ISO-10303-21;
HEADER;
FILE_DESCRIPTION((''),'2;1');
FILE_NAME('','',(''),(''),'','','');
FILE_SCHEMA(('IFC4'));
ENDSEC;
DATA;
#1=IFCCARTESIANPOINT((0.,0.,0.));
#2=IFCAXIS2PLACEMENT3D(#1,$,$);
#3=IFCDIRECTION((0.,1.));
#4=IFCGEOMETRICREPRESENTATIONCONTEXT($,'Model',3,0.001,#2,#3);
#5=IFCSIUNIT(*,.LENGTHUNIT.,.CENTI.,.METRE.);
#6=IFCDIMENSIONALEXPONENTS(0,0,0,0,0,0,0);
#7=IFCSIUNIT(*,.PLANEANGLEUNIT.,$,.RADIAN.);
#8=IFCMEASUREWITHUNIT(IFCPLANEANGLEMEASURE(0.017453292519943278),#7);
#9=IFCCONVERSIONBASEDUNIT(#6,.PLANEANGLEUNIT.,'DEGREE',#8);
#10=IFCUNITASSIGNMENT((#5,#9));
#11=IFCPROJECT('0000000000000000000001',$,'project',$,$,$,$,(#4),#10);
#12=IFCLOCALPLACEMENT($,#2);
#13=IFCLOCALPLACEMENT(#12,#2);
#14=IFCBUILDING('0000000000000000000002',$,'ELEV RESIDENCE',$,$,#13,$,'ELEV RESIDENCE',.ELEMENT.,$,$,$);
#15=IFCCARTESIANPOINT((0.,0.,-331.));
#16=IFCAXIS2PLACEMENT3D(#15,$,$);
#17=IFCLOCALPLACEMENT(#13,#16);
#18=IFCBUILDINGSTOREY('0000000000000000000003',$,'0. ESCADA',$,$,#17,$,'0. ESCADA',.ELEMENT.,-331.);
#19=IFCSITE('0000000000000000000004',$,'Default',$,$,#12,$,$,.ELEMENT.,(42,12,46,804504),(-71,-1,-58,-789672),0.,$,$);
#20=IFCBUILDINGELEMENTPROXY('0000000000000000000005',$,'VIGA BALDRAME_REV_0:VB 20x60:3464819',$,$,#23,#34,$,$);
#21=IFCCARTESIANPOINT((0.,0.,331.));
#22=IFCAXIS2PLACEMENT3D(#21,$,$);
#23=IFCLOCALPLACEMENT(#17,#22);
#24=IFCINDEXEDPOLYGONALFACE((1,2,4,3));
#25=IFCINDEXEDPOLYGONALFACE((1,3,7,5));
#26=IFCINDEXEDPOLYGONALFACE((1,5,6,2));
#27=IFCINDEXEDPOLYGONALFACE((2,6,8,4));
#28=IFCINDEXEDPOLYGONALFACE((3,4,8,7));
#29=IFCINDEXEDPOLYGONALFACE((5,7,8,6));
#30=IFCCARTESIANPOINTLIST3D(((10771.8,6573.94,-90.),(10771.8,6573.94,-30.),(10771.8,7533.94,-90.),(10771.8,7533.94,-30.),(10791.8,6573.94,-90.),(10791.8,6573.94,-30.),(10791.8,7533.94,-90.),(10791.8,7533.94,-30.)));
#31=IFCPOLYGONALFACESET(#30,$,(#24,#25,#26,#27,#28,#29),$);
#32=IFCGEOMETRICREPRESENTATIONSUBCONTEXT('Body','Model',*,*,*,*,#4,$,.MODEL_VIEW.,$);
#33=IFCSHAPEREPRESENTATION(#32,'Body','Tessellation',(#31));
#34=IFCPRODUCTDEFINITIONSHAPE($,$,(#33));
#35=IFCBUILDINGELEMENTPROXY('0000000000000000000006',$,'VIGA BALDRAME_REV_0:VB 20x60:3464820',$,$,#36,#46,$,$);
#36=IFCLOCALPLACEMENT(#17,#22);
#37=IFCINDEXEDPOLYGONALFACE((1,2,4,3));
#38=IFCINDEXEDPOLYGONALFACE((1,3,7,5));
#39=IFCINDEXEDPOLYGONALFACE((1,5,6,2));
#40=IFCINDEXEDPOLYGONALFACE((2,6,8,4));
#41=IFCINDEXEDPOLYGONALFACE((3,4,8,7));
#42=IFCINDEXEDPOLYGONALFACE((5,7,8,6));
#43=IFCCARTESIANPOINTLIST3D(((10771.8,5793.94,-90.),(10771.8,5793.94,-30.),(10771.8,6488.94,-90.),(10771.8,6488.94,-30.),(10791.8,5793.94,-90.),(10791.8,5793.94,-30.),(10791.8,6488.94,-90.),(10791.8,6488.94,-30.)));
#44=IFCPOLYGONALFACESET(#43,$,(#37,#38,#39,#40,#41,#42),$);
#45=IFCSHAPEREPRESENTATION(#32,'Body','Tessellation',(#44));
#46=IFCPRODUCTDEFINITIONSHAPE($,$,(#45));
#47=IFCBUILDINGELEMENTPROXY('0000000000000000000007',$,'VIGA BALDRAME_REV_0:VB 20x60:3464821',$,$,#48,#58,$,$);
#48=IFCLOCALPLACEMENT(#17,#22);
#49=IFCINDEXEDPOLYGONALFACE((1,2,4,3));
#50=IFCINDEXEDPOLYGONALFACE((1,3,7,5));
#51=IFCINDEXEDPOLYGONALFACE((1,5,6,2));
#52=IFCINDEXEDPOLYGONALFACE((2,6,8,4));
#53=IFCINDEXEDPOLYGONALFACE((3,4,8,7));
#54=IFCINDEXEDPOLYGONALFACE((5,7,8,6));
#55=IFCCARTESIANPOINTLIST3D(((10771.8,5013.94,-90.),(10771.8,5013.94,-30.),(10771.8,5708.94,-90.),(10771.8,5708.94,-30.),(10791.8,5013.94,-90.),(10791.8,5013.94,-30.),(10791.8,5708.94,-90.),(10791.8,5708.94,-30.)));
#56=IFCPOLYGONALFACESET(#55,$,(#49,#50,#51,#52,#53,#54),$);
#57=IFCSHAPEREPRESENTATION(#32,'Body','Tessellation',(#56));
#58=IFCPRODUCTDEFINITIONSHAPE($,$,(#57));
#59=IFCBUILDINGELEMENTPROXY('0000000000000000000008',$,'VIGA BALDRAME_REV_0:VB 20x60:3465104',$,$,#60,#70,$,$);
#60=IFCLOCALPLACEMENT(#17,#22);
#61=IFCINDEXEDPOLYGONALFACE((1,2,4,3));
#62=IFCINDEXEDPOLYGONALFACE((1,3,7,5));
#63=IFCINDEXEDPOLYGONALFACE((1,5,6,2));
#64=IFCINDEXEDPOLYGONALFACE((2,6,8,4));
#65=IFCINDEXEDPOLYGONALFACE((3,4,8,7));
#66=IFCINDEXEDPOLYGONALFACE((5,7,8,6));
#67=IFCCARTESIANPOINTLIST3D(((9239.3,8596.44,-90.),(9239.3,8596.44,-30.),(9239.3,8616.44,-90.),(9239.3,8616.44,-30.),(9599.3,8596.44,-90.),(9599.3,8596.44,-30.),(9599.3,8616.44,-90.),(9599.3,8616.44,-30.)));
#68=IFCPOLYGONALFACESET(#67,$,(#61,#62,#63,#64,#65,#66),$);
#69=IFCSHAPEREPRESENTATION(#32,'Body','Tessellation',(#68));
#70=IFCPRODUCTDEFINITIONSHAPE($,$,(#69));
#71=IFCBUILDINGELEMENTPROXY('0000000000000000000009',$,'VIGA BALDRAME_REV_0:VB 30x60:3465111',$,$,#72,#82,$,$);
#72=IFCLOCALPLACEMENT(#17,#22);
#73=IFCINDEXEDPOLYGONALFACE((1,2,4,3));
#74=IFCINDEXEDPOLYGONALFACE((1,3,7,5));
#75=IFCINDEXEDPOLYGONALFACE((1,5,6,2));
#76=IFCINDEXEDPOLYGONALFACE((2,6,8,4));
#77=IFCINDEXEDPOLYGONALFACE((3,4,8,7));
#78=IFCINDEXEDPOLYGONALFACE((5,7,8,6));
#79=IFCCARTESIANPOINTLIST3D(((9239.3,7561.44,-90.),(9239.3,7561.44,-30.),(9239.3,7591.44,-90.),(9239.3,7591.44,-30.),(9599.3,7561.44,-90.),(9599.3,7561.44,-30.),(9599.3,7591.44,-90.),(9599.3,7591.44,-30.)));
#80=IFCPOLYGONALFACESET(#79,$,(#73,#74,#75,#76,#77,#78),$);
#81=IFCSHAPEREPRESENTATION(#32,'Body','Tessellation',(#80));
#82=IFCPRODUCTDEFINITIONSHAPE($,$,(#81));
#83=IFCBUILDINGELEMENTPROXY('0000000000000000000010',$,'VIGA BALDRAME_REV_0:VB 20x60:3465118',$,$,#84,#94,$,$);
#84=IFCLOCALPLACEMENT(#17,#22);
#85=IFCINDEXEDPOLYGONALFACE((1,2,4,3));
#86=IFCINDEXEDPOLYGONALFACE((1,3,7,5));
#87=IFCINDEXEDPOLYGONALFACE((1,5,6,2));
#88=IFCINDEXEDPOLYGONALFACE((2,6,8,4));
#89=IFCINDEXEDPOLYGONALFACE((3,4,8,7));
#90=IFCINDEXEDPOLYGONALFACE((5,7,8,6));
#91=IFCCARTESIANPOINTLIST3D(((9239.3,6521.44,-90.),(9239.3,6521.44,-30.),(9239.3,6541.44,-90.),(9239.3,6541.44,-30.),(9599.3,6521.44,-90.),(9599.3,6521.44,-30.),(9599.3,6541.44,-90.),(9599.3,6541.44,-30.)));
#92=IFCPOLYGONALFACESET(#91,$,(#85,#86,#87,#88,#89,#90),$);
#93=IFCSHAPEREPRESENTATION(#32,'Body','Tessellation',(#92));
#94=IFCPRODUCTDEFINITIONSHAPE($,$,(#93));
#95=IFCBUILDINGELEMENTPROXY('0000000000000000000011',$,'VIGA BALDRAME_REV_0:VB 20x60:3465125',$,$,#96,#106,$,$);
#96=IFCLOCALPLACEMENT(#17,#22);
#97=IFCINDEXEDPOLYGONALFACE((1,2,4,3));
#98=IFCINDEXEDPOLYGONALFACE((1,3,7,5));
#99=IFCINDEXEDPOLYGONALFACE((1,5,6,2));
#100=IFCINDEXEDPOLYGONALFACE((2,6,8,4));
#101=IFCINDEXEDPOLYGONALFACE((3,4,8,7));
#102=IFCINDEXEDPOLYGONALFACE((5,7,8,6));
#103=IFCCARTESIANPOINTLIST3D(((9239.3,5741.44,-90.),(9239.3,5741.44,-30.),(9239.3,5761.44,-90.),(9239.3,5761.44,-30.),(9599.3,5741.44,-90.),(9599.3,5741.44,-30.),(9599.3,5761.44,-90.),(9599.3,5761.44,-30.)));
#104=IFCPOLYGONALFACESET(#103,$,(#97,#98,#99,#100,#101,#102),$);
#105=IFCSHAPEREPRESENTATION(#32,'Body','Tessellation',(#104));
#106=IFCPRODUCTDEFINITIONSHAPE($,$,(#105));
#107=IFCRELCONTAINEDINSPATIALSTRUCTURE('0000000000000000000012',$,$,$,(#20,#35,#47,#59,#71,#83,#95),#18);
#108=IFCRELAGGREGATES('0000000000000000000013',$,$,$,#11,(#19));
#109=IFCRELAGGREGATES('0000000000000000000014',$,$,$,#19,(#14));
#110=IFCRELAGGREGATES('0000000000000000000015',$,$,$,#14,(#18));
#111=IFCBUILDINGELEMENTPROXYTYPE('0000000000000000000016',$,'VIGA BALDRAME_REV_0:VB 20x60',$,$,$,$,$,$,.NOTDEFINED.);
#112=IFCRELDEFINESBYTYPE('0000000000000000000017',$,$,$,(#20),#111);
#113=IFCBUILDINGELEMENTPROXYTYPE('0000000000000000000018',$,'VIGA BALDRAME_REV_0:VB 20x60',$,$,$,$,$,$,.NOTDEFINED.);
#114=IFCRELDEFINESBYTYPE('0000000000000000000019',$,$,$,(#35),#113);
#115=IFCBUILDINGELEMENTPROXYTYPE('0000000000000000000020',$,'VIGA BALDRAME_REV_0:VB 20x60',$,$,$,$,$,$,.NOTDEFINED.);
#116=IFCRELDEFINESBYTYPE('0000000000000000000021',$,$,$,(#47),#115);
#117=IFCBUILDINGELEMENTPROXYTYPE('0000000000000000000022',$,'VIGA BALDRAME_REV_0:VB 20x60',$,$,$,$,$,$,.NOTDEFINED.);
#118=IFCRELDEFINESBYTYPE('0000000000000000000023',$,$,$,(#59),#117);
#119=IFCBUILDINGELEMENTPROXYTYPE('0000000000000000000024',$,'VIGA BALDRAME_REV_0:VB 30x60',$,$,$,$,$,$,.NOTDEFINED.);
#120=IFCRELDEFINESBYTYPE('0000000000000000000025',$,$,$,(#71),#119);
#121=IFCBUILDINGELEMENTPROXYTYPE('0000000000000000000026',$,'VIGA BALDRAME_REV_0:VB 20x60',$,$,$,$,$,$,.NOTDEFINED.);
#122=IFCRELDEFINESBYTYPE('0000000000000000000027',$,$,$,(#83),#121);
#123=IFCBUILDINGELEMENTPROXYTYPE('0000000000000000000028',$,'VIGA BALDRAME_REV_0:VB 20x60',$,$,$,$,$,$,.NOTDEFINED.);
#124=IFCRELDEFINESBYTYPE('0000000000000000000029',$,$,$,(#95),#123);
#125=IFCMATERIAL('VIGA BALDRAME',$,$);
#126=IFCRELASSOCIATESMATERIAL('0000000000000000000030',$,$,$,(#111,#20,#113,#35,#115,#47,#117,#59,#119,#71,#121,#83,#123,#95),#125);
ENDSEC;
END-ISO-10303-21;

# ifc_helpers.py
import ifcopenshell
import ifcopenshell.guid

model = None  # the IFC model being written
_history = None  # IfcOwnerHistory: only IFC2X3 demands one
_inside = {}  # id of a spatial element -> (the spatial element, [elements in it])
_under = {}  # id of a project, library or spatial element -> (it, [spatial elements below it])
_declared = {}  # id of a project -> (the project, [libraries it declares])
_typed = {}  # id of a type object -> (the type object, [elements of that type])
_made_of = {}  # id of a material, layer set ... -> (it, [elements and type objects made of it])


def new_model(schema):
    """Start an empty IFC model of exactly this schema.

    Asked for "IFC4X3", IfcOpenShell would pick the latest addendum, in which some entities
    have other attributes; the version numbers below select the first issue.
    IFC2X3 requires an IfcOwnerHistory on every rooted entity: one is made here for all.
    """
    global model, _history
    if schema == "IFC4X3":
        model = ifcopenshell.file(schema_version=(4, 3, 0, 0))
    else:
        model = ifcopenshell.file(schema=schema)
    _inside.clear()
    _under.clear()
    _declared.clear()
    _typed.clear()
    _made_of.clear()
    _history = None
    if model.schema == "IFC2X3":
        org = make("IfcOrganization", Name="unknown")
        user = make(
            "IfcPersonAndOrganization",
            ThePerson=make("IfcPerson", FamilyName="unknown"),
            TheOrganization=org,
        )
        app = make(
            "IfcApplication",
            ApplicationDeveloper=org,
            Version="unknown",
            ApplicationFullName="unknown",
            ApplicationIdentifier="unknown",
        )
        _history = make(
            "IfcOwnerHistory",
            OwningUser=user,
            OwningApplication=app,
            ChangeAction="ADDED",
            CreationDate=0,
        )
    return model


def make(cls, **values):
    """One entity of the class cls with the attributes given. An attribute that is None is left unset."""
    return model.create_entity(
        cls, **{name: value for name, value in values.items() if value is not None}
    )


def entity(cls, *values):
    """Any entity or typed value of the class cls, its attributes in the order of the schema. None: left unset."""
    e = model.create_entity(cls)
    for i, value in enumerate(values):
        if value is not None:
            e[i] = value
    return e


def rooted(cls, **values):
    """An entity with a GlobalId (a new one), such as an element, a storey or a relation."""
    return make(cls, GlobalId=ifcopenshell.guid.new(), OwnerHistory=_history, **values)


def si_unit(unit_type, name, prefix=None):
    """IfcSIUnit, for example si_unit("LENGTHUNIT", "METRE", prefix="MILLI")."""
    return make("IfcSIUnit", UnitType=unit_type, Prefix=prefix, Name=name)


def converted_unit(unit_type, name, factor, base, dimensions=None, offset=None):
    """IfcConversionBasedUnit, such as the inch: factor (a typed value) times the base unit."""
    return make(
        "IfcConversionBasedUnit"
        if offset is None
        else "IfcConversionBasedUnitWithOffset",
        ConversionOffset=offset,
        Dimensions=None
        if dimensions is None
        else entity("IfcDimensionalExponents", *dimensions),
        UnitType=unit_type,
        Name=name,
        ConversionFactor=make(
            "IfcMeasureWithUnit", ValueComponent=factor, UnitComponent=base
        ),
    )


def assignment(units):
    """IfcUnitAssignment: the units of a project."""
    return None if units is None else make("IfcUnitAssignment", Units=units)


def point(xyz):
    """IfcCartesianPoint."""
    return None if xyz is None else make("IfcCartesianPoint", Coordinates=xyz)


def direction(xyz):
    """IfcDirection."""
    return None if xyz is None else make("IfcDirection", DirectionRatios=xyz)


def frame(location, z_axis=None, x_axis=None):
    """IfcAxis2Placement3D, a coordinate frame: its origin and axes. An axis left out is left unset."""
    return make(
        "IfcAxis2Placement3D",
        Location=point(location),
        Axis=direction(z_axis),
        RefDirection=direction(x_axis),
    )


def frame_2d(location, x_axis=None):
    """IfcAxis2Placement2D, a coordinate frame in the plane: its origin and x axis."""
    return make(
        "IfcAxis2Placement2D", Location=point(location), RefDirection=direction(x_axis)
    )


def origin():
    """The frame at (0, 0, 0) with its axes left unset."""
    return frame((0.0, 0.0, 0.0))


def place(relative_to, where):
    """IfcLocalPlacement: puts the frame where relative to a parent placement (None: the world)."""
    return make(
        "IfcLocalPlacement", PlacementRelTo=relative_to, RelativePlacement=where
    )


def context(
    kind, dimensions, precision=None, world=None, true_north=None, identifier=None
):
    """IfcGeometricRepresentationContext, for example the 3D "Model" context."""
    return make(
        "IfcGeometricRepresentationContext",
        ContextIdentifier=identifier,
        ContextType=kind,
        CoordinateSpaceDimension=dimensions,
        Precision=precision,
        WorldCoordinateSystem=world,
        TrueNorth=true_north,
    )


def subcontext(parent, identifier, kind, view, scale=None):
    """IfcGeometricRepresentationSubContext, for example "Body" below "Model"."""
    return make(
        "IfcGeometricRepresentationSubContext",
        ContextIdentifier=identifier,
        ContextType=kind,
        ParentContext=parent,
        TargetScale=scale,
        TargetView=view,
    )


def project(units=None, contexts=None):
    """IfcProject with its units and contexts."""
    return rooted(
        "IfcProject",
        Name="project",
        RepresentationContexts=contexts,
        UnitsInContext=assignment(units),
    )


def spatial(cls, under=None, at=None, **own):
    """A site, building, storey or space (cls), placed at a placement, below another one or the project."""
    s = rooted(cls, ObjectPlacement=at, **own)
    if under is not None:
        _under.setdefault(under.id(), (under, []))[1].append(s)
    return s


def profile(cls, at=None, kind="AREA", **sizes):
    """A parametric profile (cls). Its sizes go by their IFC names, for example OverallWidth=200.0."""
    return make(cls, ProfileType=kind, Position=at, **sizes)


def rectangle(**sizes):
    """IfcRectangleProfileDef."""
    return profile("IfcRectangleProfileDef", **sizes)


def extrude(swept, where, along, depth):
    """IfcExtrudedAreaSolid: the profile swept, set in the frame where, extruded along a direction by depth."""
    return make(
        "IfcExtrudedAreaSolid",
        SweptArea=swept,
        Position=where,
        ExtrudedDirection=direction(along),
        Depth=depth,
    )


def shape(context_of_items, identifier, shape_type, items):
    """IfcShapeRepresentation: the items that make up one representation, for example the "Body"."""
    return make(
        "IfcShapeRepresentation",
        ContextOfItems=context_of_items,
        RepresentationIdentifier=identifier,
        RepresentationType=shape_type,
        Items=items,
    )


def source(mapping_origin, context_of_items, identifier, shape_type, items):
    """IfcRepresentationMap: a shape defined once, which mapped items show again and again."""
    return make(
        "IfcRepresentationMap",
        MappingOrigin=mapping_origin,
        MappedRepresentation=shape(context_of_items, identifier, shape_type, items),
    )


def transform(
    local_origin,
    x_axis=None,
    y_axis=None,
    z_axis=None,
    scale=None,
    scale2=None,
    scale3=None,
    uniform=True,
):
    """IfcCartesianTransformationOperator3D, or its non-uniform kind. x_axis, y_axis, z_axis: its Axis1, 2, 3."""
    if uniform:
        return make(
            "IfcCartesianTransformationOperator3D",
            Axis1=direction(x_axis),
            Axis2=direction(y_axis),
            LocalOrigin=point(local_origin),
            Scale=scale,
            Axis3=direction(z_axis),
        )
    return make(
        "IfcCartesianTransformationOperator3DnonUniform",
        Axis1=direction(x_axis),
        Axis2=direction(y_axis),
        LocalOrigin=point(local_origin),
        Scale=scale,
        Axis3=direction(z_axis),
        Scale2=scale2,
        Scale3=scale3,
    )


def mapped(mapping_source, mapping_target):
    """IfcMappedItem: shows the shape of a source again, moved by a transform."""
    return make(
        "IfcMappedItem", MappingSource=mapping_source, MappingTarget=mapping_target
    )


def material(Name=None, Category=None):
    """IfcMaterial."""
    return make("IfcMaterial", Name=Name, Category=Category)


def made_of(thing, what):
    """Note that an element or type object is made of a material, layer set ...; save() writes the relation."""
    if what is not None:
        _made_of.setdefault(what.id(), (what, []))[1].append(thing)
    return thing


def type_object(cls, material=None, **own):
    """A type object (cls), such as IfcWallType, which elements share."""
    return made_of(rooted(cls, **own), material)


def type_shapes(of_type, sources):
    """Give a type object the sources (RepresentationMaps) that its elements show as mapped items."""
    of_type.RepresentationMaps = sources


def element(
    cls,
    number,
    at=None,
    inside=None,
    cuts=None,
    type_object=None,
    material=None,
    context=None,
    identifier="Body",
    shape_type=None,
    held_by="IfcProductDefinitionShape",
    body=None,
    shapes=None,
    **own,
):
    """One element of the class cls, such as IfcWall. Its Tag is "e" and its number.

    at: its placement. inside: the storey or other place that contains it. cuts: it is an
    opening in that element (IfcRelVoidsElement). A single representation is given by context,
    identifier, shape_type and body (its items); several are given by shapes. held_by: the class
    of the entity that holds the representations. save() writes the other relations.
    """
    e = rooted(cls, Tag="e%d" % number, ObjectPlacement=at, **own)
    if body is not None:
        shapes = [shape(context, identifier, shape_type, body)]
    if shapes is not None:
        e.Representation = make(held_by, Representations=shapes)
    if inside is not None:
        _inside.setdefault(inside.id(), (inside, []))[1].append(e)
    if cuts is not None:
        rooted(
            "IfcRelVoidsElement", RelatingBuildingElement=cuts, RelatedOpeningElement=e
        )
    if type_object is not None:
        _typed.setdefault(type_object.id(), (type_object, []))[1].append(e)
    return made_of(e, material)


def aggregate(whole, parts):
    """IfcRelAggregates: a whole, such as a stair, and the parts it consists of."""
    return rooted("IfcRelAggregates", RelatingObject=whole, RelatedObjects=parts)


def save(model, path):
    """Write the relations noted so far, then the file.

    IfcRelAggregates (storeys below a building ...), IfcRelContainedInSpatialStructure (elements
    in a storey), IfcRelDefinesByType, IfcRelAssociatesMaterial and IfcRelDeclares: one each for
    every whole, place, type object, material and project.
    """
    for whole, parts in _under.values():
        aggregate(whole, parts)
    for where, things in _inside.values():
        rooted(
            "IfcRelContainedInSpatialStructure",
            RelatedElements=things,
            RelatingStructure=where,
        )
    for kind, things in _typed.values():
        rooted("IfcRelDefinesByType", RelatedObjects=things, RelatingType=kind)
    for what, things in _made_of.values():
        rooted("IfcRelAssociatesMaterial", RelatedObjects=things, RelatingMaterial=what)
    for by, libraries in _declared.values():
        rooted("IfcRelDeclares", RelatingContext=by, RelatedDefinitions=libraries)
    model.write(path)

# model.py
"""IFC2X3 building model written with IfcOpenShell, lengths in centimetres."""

from ifc_helpers import new_model, entity, si_unit, converted_unit, direction, frame, frame_2d, origin, place, context, subcontext, project, spatial, rectangle, extrude, source, transform, mapped, material, type_object, type_shapes, element, save


model = new_model("IFC2X3")

# Units and contexts
model_context = context("Model", 3, precision=0.001, world=origin(), true_north=direction((0.0, 1.0)))
body_context = subcontext(model_context, "Body", "Model", "MODEL_VIEW")
ifc_project = project(units=[si_unit("LENGTHUNIT", "METRE", prefix="CENTI"), converted_unit("PLANEANGLEUNIT", "DEGREE", entity("IfcPlaneAngleMeasure", 0.017453292519943278), si_unit("PLANEANGLEUNIT", "RADIAN"), dimensions=[0, 0, 0, 0, 0, 0, 0])], contexts=[model_context])

# Site, building, storey
site_placement = place(None, origin())
site = spatial("IfcSite", under=ifc_project, at=site_placement, Name="Default", CompositionType="ELEMENT", RefLatitude=(42, 12, 46, 804504), RefLongitude=(-71, -1, -58, -789672), RefElevation=0.0)
building_placement = place(site_placement, origin())
building = spatial("IfcBuilding", under=site, at=building_placement, Name="ELEV RESIDENCE", LongName="ELEV RESIDENCE", CompositionType="ELEMENT")
storey_placement = place(building_placement, frame((0.0, 0.0, -331.0)))
storey = spatial("IfcBuildingStorey", under=building, at=storey_placement, Name="0. ESCADA", LongName="0. ESCADA", CompositionType="ELEMENT", Elevation=-331.0)

# Building element proxies
ifc_material = material(Name="VIGA BALDRAME")
building_element_proxy_type_1 = type_object("IfcBuildingElementProxyType", Name="VIGA BALDRAME_REV_0:VB 20x60", PredefinedType="NOTDEFINED", material=ifc_material)
shared_shape_1 = source(origin(), body_context, "Body", "SweptSolid", [
    extrude(rectangle(XDim=20.0, YDim=960.0, at=frame_2d((0.0, 0.0), x_axis=(1.0, 0.0))), frame((10781.8, 7053.94, -90.0), z_axis=(0.0, 0.0, 1.0), x_axis=(-1.0, 0.0, 0.0)), (0.0, 0.0, 1.0), 60.0),
])
type_shapes(building_element_proxy_type_1, [shared_shape_1])
proxy_1_placement = place(storey_placement, frame((0.0, 0.0, 331.0)))
element("IfcBuildingElementProxy", 1, at=proxy_1_placement, inside=storey, type_object=building_element_proxy_type_1, material=ifc_material, Name="VIGA BALDRAME_REV_0:VB 20x60:3464819", context=body_context, shape_type="MappedRepresentation", body=[
    mapped(shared_shape_1, transform((0.0, 0.0, 0.0), scale=1.0)),
])
building_element_proxy_type_2 = type_object("IfcBuildingElementProxyType", Name="VIGA BALDRAME_REV_0:VB 20x60", PredefinedType="NOTDEFINED", material=ifc_material)
shared_shape_2 = source(origin(), body_context, "Body", "SweptSolid", [
    extrude(rectangle(XDim=695.0, YDim=20.0, at=frame_2d((0.0, 0.0), x_axis=(1.0, 0.0))), frame((10781.8, 6141.44, -90.0), z_axis=(0.0, 0.0, 1.0), x_axis=(0.0, 1.0, 0.0)), (0.0, 0.0, 1.0), 60.0),
])
type_shapes(building_element_proxy_type_2, [shared_shape_2])
proxy_2_placement = place(storey_placement, frame((0.0, 0.0, 331.0)))
element("IfcBuildingElementProxy", 2, at=proxy_2_placement, inside=storey, type_object=building_element_proxy_type_2, material=ifc_material, Name="VIGA BALDRAME_REV_0:VB 20x60:3464820", context=body_context, shape_type="MappedRepresentation", body=[
    mapped(shared_shape_2, transform((0.0, 0.0, 0.0), scale=1.0)),
])
building_element_proxy_type_3 = type_object("IfcBuildingElementProxyType", Name="VIGA BALDRAME_REV_0:VB 20x60", PredefinedType="NOTDEFINED", material=ifc_material)
shared_shape_3 = source(origin(), body_context, "Body", "SweptSolid", [
    extrude(rectangle(XDim=20.0, YDim=695.0, at=frame_2d((0.0, 0.0), x_axis=(1.0, 0.0))), frame((10781.8, 5361.44, -90.0), z_axis=(0.0, 0.0, 1.0), x_axis=(-1.0, 0.0, 0.0)), (0.0, 0.0, 1.0), 60.0),
])
type_shapes(building_element_proxy_type_3, [shared_shape_3])
proxy_3_placement = place(storey_placement, frame((0.0, 0.0, 331.0)))
element("IfcBuildingElementProxy", 3, at=proxy_3_placement, inside=storey, type_object=building_element_proxy_type_3, material=ifc_material, Name="VIGA BALDRAME_REV_0:VB 20x60:3464821", context=body_context, shape_type="MappedRepresentation", body=[
    mapped(shared_shape_3, transform((0.0, 0.0, 0.0), scale=1.0)),
])
building_element_proxy_type_4 = type_object("IfcBuildingElementProxyType", Name="VIGA BALDRAME_REV_0:VB 20x60", PredefinedType="NOTDEFINED", material=ifc_material)
shared_shape_4 = source(origin(), body_context, "Body", "SweptSolid", [
    extrude(rectangle(XDim=20.0, YDim=360.0, at=frame_2d((0.0, 0.0), x_axis=(1.0, 0.0))), frame((9419.3, 8606.44, -90.0), z_axis=(0.0, 0.0, 1.0), x_axis=(0.0, -1.0, 0.0)), (0.0, 0.0, 1.0), 60.0),
])
type_shapes(building_element_proxy_type_4, [shared_shape_4])
proxy_4_placement = place(storey_placement, frame((0.0, 0.0, 331.0)))
element("IfcBuildingElementProxy", 4, at=proxy_4_placement, inside=storey, type_object=building_element_proxy_type_4, material=ifc_material, Name="VIGA BALDRAME_REV_0:VB 20x60:3465104", context=body_context, shape_type="MappedRepresentation", body=[
    mapped(shared_shape_4, transform((0.0, 0.0, 0.0), scale=1.0)),
])
building_element_proxy_type_5 = type_object("IfcBuildingElementProxyType", Name="VIGA BALDRAME_REV_0:VB 30x60", PredefinedType="NOTDEFINED", material=ifc_material)
shared_shape_5 = source(origin(), body_context, "Body", "SweptSolid", [
    extrude(rectangle(XDim=30.0, YDim=360.0, at=frame_2d((0.0, 0.0), x_axis=(1.0, 0.0))), frame((9419.3, 7576.44, -90.0), z_axis=(0.0, 0.0, 1.0), x_axis=(0.0, -1.0, 0.0)), (0.0, 0.0, 1.0), 60.0),
])
type_shapes(building_element_proxy_type_5, [shared_shape_5])
proxy_5_placement = place(storey_placement, frame((0.0, 0.0, 331.0)))
element("IfcBuildingElementProxy", 5, at=proxy_5_placement, inside=storey, type_object=building_element_proxy_type_5, material=ifc_material, Name="VIGA BALDRAME_REV_0:VB 30x60:3465111", context=body_context, shape_type="MappedRepresentation", body=[
    mapped(shared_shape_5, transform((0.0, 0.0, 0.0), scale=1.0)),
])
building_element_proxy_type_6 = type_object("IfcBuildingElementProxyType", Name="VIGA BALDRAME_REV_0:VB 20x60", PredefinedType="NOTDEFINED", material=ifc_material)
shared_shape_6 = source(origin(), body_context, "Body", "SweptSolid", [
    extrude(rectangle(XDim=20.0, YDim=360.0, at=frame_2d((0.0, 0.0), x_axis=(1.0, 0.0))), frame((9419.3, 6531.44, -90.0), z_axis=(0.0, 0.0, 1.0), x_axis=(0.0, -1.0, 0.0)), (0.0, 0.0, 1.0), 60.0),
])
type_shapes(building_element_proxy_type_6, [shared_shape_6])
proxy_6_placement = place(storey_placement, frame((0.0, 0.0, 331.0)))
element("IfcBuildingElementProxy", 6, at=proxy_6_placement, inside=storey, type_object=building_element_proxy_type_6, material=ifc_material, Name="VIGA BALDRAME_REV_0:VB 20x60:3465118", context=body_context, shape_type="MappedRepresentation", body=[
    mapped(shared_shape_6, transform((0.0, 0.0, 0.0), scale=1.0)),
])
building_element_proxy_type_7 = type_object("IfcBuildingElementProxyType", Name="VIGA BALDRAME_REV_0:VB 20x60", PredefinedType="NOTDEFINED", material=ifc_material)
shared_shape_7 = source(origin(), body_context, "Body", "SweptSolid", [
    extrude(rectangle(XDim=20.0, YDim=360.0, at=frame_2d((0.0, 0.0), x_axis=(1.0, 0.0))), frame((9419.3, 5751.44, -90.0), z_axis=(0.0, 0.0, 1.0), x_axis=(0.0, -1.0, 0.0)), (0.0, 0.0, 1.0), 60.0),
])
type_shapes(building_element_proxy_type_7, [shared_shape_7])
proxy_7_placement = place(storey_placement, frame((0.0, 0.0, 331.0)))
element("IfcBuildingElementProxy", 7, at=proxy_7_placement, inside=storey, type_object=building_element_proxy_type_7, material=ifc_material, Name="VIGA BALDRAME_REV_0:VB 20x60:3465125", context=body_context, shape_type="MappedRepresentation", body=[
    mapped(shared_shape_7, transform((0.0, 0.0, 0.0), scale=1.0)),
])

save(model, "model.ifc")
